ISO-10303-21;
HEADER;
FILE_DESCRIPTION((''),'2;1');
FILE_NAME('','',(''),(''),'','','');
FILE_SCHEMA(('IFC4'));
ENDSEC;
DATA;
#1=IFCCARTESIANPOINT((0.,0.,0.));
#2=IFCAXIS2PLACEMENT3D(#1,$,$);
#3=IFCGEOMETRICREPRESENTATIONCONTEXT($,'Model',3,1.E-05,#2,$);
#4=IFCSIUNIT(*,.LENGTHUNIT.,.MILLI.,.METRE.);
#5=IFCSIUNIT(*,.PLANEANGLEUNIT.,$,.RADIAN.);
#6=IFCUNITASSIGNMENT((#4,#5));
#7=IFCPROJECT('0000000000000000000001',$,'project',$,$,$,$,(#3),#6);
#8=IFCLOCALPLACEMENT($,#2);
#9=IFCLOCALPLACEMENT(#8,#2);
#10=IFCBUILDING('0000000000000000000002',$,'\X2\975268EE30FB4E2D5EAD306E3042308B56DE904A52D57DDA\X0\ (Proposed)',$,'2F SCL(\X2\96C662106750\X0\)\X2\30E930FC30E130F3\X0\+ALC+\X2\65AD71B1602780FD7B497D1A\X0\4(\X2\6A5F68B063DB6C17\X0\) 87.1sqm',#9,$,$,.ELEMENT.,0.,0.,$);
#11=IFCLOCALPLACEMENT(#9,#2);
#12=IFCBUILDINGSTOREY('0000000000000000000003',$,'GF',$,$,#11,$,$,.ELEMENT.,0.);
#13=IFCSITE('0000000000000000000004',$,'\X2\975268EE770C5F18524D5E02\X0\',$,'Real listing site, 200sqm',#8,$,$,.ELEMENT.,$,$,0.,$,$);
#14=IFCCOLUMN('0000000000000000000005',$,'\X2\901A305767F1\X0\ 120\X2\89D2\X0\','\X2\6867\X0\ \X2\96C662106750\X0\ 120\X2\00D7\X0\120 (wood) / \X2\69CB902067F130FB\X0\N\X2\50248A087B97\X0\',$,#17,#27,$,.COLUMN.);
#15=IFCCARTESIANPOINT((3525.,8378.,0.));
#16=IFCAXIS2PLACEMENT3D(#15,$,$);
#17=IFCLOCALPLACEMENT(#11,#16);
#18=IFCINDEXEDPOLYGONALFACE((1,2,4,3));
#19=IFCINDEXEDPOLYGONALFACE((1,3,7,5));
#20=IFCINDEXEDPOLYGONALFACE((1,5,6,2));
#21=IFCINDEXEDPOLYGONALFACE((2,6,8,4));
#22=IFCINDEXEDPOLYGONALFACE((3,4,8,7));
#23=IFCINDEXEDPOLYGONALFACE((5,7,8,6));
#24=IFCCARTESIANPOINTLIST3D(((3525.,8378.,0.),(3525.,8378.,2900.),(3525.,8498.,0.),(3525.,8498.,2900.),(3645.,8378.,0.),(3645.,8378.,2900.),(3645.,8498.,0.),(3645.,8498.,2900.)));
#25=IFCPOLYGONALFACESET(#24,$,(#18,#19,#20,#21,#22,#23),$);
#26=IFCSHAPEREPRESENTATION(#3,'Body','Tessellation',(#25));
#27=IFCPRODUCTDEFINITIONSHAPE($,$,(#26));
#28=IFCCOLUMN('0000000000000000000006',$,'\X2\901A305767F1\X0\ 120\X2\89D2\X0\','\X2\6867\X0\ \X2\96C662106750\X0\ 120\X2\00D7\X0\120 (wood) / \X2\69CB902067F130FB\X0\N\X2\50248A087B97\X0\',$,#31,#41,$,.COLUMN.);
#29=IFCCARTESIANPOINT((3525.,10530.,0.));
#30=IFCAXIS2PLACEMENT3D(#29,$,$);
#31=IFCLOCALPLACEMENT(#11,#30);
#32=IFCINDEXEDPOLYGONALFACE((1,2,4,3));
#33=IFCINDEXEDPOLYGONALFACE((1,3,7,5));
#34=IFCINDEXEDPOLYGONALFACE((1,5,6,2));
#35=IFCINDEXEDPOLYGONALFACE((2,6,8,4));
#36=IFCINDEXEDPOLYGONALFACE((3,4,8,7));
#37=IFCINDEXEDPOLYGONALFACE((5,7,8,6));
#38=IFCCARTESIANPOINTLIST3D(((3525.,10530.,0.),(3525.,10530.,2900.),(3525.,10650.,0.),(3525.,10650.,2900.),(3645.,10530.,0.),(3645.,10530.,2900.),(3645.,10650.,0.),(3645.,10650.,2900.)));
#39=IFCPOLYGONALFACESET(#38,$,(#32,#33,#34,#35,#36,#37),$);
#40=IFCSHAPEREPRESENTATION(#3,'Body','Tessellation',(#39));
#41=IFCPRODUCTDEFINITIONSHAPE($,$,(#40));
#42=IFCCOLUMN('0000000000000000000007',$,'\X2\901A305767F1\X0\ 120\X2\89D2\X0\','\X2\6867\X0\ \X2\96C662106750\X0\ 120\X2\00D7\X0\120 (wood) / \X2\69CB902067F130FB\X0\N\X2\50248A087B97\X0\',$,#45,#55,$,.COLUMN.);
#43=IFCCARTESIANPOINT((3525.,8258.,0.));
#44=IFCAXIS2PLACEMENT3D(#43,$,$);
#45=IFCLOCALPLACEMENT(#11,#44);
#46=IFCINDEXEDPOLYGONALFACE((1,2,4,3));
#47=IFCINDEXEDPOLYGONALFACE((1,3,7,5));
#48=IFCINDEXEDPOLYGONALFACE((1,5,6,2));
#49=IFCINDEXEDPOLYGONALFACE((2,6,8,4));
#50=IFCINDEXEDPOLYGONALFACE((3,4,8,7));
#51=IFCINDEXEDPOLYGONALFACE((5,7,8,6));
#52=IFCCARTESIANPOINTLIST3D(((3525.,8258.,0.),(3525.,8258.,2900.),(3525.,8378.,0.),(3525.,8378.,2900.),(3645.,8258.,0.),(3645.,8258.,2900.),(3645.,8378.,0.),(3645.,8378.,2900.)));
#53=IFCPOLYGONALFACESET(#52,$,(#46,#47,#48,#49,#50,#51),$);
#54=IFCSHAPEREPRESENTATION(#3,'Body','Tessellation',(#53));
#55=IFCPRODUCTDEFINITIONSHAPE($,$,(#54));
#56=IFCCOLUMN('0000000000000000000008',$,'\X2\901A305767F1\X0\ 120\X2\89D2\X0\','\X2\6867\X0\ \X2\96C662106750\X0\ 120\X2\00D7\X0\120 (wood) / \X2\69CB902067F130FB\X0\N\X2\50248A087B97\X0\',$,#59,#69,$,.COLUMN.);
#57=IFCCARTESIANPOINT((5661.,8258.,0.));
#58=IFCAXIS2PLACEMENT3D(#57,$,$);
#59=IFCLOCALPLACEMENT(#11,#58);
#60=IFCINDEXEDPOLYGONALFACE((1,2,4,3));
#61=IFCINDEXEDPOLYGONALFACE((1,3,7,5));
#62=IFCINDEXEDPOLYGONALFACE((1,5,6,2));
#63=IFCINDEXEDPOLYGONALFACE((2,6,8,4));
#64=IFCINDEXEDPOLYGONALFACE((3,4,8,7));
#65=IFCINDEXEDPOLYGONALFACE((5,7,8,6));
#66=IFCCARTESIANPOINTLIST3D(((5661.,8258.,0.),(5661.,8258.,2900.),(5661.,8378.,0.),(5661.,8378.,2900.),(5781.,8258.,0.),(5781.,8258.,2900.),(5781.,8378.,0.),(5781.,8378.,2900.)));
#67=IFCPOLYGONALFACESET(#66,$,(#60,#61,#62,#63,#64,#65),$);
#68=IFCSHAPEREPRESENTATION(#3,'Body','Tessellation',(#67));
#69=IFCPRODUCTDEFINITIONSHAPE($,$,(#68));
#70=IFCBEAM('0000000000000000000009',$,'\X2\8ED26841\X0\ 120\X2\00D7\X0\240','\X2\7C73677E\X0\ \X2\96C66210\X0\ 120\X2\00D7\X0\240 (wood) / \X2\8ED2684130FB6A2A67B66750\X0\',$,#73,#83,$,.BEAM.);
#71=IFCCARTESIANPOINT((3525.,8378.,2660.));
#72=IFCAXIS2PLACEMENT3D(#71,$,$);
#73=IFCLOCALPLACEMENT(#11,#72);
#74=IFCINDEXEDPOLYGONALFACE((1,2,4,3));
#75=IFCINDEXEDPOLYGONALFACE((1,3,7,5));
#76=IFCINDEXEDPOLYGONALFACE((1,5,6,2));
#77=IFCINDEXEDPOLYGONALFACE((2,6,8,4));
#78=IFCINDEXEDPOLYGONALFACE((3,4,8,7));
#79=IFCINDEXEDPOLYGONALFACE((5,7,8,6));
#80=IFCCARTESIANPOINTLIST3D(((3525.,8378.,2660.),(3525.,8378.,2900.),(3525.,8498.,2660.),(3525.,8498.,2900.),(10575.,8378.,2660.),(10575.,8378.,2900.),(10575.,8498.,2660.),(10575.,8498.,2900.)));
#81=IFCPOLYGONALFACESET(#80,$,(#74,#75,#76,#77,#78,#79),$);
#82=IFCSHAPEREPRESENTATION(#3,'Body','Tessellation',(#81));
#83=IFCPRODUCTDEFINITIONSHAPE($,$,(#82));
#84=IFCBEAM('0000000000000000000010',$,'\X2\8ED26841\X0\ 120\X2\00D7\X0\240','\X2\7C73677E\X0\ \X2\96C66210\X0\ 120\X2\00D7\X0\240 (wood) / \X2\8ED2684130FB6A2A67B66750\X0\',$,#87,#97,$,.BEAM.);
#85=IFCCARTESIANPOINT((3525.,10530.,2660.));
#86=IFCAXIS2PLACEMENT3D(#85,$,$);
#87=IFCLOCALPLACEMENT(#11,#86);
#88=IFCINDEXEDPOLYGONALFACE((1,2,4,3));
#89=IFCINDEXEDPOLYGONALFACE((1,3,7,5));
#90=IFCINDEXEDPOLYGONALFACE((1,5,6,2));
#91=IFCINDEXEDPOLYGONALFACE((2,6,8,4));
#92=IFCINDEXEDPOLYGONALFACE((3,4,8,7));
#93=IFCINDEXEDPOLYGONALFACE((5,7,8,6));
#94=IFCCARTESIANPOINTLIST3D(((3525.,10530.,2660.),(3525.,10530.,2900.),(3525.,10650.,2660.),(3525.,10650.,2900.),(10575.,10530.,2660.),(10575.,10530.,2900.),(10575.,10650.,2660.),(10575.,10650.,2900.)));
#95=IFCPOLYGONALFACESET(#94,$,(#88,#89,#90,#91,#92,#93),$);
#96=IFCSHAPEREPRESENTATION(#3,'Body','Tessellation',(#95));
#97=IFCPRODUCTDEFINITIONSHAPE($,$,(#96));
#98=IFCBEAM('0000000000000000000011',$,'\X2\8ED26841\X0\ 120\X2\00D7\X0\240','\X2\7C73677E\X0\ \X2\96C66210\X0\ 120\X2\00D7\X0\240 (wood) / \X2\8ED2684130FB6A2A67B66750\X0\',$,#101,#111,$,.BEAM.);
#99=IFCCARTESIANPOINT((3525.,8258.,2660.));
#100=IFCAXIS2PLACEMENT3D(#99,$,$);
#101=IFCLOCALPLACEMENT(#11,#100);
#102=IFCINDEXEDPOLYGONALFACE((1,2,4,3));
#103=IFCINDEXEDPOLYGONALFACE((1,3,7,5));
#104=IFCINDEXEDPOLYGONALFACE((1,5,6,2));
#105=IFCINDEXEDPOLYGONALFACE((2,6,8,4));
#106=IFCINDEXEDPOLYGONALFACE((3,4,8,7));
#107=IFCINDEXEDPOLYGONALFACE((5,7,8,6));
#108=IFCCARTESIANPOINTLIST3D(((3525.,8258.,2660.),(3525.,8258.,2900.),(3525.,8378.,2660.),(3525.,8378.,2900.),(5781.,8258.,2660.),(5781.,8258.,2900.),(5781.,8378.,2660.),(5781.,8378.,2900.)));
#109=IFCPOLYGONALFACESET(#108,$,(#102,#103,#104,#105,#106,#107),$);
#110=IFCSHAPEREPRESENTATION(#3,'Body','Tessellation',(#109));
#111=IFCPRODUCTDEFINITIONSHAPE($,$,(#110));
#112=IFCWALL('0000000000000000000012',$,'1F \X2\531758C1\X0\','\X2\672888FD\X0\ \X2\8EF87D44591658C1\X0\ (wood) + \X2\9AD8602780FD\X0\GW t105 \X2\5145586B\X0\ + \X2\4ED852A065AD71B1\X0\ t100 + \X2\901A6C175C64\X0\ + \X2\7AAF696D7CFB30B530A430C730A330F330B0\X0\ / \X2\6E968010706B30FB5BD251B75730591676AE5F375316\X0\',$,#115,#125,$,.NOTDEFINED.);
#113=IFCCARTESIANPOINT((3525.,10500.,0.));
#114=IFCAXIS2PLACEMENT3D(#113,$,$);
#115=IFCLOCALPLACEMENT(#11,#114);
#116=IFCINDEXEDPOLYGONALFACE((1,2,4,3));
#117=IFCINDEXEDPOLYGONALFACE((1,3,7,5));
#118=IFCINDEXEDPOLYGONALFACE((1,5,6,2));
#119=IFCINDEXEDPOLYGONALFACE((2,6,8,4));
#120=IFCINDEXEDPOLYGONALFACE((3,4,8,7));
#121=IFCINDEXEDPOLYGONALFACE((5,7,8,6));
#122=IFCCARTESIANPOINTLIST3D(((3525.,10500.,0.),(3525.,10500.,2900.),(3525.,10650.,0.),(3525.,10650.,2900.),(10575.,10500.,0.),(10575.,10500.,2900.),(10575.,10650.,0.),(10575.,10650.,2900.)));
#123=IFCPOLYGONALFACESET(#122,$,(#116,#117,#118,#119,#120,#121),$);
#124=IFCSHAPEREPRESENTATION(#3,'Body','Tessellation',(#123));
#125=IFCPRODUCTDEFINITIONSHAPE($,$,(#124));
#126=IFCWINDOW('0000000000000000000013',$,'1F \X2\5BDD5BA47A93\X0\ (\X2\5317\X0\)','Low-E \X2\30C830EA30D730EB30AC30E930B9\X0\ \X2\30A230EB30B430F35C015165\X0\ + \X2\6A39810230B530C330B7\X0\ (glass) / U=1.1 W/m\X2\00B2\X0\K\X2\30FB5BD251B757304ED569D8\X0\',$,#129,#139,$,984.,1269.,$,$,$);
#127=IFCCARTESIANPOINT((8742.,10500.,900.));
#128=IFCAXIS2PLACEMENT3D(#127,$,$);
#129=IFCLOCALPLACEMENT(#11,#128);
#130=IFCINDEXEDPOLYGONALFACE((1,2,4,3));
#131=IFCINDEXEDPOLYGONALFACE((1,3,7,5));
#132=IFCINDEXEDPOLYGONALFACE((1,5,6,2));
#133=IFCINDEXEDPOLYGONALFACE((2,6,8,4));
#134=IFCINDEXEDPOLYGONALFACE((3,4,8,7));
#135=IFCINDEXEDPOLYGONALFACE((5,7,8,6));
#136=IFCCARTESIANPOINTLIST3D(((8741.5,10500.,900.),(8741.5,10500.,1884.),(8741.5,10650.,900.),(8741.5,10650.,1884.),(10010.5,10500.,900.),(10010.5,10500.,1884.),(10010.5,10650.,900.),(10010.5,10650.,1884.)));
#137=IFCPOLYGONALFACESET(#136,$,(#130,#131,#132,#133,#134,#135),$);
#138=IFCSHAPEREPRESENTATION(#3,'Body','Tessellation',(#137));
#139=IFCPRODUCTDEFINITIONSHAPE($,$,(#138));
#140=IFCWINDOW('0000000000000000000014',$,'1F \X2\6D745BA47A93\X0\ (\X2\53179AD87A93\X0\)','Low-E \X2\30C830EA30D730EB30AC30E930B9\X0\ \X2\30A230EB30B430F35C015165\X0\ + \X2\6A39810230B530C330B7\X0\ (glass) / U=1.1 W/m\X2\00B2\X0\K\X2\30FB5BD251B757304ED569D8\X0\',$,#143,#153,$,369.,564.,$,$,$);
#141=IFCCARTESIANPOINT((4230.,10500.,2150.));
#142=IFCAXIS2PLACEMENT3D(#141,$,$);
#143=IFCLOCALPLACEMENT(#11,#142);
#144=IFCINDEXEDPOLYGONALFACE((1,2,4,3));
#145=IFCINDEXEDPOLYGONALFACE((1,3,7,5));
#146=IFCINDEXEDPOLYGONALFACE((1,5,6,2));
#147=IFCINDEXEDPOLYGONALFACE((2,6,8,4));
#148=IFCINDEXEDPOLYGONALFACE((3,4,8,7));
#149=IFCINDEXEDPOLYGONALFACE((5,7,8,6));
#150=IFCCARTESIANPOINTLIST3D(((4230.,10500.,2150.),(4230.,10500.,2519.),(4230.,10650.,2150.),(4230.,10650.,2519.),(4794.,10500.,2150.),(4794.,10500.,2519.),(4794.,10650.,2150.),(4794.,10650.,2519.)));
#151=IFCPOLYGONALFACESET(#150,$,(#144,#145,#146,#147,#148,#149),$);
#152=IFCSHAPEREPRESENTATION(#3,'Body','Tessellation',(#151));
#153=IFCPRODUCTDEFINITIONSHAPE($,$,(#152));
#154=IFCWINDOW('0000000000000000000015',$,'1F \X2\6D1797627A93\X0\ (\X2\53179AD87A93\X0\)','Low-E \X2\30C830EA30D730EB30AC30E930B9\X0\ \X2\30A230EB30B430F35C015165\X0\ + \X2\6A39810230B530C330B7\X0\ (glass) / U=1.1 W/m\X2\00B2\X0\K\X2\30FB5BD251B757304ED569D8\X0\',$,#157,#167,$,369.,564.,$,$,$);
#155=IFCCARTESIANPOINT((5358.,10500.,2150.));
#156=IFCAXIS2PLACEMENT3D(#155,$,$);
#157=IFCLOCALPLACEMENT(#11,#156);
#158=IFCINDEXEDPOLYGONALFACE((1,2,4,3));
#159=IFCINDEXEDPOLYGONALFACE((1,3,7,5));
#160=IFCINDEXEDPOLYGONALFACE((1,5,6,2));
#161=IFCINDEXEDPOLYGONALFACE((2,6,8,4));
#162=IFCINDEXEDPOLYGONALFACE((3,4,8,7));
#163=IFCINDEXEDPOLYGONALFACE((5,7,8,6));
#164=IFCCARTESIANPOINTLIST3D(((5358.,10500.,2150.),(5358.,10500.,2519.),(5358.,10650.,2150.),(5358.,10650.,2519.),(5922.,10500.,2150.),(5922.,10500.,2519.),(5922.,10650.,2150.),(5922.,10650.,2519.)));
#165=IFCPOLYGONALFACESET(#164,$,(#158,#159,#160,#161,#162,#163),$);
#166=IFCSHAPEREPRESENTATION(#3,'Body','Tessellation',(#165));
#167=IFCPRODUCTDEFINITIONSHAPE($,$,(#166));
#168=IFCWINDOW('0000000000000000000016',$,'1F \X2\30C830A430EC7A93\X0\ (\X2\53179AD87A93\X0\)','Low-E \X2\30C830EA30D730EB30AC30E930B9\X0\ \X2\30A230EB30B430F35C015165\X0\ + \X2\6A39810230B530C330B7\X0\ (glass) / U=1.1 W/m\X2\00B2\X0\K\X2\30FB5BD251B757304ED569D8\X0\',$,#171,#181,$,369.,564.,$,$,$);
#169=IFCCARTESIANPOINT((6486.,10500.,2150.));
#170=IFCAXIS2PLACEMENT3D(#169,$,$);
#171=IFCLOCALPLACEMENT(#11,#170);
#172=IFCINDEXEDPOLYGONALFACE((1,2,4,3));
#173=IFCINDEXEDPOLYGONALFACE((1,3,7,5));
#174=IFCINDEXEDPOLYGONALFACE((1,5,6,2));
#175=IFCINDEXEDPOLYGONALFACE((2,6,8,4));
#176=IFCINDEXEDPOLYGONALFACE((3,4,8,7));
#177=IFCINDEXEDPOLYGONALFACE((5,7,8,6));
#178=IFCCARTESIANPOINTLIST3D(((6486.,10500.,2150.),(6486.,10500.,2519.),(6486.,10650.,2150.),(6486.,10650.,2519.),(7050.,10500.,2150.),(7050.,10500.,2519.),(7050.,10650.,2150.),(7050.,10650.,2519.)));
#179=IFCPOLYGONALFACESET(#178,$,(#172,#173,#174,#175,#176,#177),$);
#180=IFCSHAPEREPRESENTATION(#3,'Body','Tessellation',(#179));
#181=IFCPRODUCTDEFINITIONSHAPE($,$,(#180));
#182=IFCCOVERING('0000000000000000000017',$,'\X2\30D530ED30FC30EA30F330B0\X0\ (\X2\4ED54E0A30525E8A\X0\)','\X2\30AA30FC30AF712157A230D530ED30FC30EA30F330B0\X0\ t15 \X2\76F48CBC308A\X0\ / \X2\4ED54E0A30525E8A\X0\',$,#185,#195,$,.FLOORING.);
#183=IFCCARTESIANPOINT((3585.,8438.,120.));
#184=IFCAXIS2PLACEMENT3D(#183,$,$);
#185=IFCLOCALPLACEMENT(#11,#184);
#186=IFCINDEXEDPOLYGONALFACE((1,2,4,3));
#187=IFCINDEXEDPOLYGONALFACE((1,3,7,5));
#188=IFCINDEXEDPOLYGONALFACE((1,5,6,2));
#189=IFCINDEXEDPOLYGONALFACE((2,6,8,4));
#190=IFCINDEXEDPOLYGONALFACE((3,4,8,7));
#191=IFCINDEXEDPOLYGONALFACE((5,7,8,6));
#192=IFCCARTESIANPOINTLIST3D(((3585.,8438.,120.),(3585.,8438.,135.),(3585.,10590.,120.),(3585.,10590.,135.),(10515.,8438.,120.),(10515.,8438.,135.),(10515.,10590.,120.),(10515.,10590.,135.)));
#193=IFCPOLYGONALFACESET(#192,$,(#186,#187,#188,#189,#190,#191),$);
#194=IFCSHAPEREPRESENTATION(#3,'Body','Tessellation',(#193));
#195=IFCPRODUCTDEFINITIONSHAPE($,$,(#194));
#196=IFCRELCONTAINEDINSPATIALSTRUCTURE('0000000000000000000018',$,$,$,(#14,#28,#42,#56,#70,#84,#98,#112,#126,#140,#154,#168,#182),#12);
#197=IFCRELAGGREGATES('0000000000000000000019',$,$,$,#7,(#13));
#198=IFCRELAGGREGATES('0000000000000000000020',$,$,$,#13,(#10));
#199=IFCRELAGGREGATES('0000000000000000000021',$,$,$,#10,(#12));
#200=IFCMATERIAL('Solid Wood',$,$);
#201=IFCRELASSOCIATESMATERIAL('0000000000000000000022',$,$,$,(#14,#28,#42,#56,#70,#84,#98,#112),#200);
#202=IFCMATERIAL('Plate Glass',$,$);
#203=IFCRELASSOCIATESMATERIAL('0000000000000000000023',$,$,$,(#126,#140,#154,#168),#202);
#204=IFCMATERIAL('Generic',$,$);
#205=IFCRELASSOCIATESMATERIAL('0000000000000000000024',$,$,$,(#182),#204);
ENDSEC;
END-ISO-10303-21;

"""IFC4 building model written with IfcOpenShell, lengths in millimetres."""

from ifc_helpers import new_model, si_unit, frame, frame_2d, origin, place, context, project, spatial, rectangle, extrude, material, element, fill, save


model = new_model("IFC4")

# Units and contexts
model_context = context("Model", 3, precision=1e-05, world=origin())
ifc_project = project(units=[si_unit("LENGTHUNIT", "METRE", prefix="MILLI"), si_unit("PLANEANGLEUNIT", "RADIAN")], contexts=[model_context])

# Site, building, storey
site_placement = place(None, origin())
site = spatial("IfcSite", under=ifc_project, at=site_placement, Name="青森県弘前市", ObjectType="Real listing site, 200sqm", CompositionType="ELEMENT", RefElevation=0.0)
building_placement = place(site_placement, origin())
building = spatial("IfcBuilding", under=site, at=building_placement, Name="青森・中庭のある回遊動線 (Proposed)", ObjectType="2F SCL(集成材)ラーメン+ALC+断熱性能等級4(機械換気) 87.1sqm", CompositionType="ELEMENT", ElevationOfRefHeight=0.0, ElevationOfTerrain=0.0)
storey_placement = place(building_placement, origin())
storey = spatial("IfcBuildingStorey", under=building, at=storey_placement, Name="GF", CompositionType="ELEMENT", Elevation=0.0)

# Columns
ifc_material_1 = material(Name="Solid Wood")
column_1_placement = place(storey_placement, frame((3525.0, 8378.0, 0.0)))
element("IfcColumn", 1, at=column_1_placement, inside=storey, material=ifc_material_1, Name="通し柱 120角", Description="桧 集成材 120×120 (wood) / 構造柱・N値計算", PredefinedType="COLUMN", context=model_context, shape_type="SweptSolid", body=[
    extrude(rectangle(XDim=120.0, YDim=120.0, at=frame_2d((60.0, 60.0))), frame((3525.0, 8378.0, 0.0)), (0.0, 0.0, 1.0), 2900.0),
])
column_2_placement = place(storey_placement, frame((3525.0, 10530.0, 0.0)))
element("IfcColumn", 2, at=column_2_placement, inside=storey, material=ifc_material_1, Name="通し柱 120角", Description="桧 集成材 120×120 (wood) / 構造柱・N値計算", PredefinedType="COLUMN", context=model_context, shape_type="SweptSolid", body=[
    extrude(rectangle(XDim=120.0, YDim=120.0, at=frame_2d((60.0, 60.0))), frame((3525.0, 10530.0, 0.0)), (0.0, 0.0, 1.0), 2900.0),
])
column_3_placement = place(storey_placement, frame((3525.0, 8258.0, 0.0)))
element("IfcColumn", 3, at=column_3_placement, inside=storey, material=ifc_material_1, Name="通し柱 120角", Description="桧 集成材 120×120 (wood) / 構造柱・N値計算", PredefinedType="COLUMN", context=model_context, shape_type="SweptSolid", body=[
    extrude(rectangle(XDim=120.0, YDim=120.0, at=frame_2d((60.0, 60.0))), frame((3525.0, 8258.0, 0.0)), (0.0, 0.0, 1.0), 2900.0),
])
column_4_placement = place(storey_placement, frame((5661.0, 8258.0, 0.0)))
element("IfcColumn", 4, at=column_4_placement, inside=storey, material=ifc_material_1, Name="通し柱 120角", Description="桧 集成材 120×120 (wood) / 構造柱・N値計算", PredefinedType="COLUMN", context=model_context, shape_type="SweptSolid", body=[
    extrude(rectangle(XDim=120.0, YDim=120.0, at=frame_2d((60.0, 60.0))), frame((5661.0, 8258.0, 0.0)), (0.0, 0.0, 1.0), 2900.0),
])

# Beams
beam_1_placement = place(storey_placement, frame((3525.0, 8378.0, 2660.0)))
element("IfcBeam", 5, at=beam_1_placement, inside=storey, material=ifc_material_1, Name="軒桁 120×240", Description="米松 集成 120×240 (wood) / 軒桁・横架材", PredefinedType="BEAM", context=model_context, shape_type="SweptSolid", body=[
    extrude(rectangle(XDim=7050.0, YDim=120.0, at=frame_2d((3525.0, 60.0))), frame((3525.0, 8378.0, 2660.0)), (0.0, 0.0, 1.0), 240.0),
])
beam_2_placement = place(storey_placement, frame((3525.0, 10530.0, 2660.0)))
element("IfcBeam", 6, at=beam_2_placement, inside=storey, material=ifc_material_1, Name="軒桁 120×240", Description="米松 集成 120×240 (wood) / 軒桁・横架材", PredefinedType="BEAM", context=model_context, shape_type="SweptSolid", body=[
    extrude(rectangle(XDim=7050.0, YDim=120.0, at=frame_2d((3525.0, 60.0))), frame((3525.0, 10530.0, 2660.0)), (0.0, 0.0, 1.0), 240.0),
])
beam_3_placement = place(storey_placement, frame((3525.0, 8258.0, 2660.0)))
element("IfcBeam", 7, at=beam_3_placement, inside=storey, material=ifc_material_1, Name="軒桁 120×240", Description="米松 集成 120×240 (wood) / 軒桁・横架材", PredefinedType="BEAM", context=model_context, shape_type="SweptSolid", body=[
    extrude(rectangle(XDim=2256.0, YDim=120.0, at=frame_2d((1128.0, 60.0))), frame((3525.0, 8258.0, 2660.0)), (0.0, 0.0, 1.0), 240.0),
])

# Wall, openings, windows
wall_1_placement = place(storey_placement, frame((3525.0, 10500.0, 0.0)))
wall_1 = element("IfcWall", 8, at=wall_1_placement, inside=storey, material=ifc_material_1, Name="1F 北壁", Description="木製 軸組外壁 (wood) + 高性能GW t105 充填 + 付加断熱 t100 + 通気層 + 窯業系サイディング / 準耐火・寒冷地外皮強化", PredefinedType="NOTDEFINED", context=model_context, shape_type="SweptSolid", body=[
    extrude(rectangle(XDim=7050.0, YDim=150.0, at=frame_2d((3525.0, 75.0))), frame((3525.0, 10500.0, 0.0)), (0.0, 0.0, 1.0), 2900.0),
])
opening_1_placement = place(storey_placement, frame((8742.0, 10500.0, 900.0)))
opening_1 = element("IfcOpeningElement", 9, at=opening_1_placement, cuts=wall_1, PredefinedType="NOTDEFINED", context=model_context, shape_type="SweptSolid", body=[
    extrude(rectangle(XDim=1269.0, YDim=150.0, at=frame_2d((634.0, 75.0))), frame((8742.0, 10500.0, 900.0)), (0.0, 0.0, 1.0), 984.0),
])
opening_2_placement = place(storey_placement, frame((4230.0, 10500.0, 2150.0)))
opening_2 = element("IfcOpeningElement", 10, at=opening_2_placement, cuts=wall_1, PredefinedType="NOTDEFINED", context=model_context, shape_type="SweptSolid", body=[
    extrude(rectangle(XDim=564.0, YDim=150.0, at=frame_2d((282.0, 75.0))), frame((4230.0, 10500.0, 2150.0)), (0.0, 0.0, 1.0), 369.0),
])
opening_3_placement = place(storey_placement, frame((5358.0, 10500.0, 2150.0)))
opening_3 = element("IfcOpeningElement", 11, at=opening_3_placement, cuts=wall_1, PredefinedType="NOTDEFINED", context=model_context, shape_type="SweptSolid", body=[
    extrude(rectangle(XDim=564.0, YDim=150.0, at=frame_2d((282.0, 75.0))), frame((5358.0, 10500.0, 2150.0)), (0.0, 0.0, 1.0), 369.0),
])
opening_4_placement = place(storey_placement, frame((6486.0, 10500.0, 2150.0)))
opening_4 = element("IfcOpeningElement", 12, at=opening_4_placement, cuts=wall_1, PredefinedType="NOTDEFINED", context=model_context, shape_type="SweptSolid", body=[
    extrude(rectangle(XDim=564.0, YDim=150.0, at=frame_2d((282.0, 75.0))), frame((6486.0, 10500.0, 2150.0)), (0.0, 0.0, 1.0), 369.0),
])
ifc_material_2 = material(Name="Plate Glass")
window_1_placement = place(storey_placement, frame((8742.0, 10500.0, 900.0)))
window_1 = element("IfcWindow", 13, at=window_1_placement, inside=storey, material=ifc_material_2, Name="1F 寝室窓 (北)", Description="Low-E トリプルガラス アルゴン封入 + 樹脂サッシ (glass) / U=1.1 W/m²K・寒冷地仕様", OverallHeight=984.0, OverallWidth=1269.0, context=model_context, shape_type="SweptSolid", body=[
    extrude(rectangle(XDim=1269.0, YDim=150.0, at=frame_2d((634.0, 75.0))), frame((8742.0, 10500.0, 900.0)), (0.0, 0.0, 1.0), 984.0),
])
fill(opening_1, window_1)
window_2_placement = place(storey_placement, frame((4230.0, 10500.0, 2150.0)))
window_2 = element("IfcWindow", 14, at=window_2_placement, inside=storey, material=ifc_material_2, Name="1F 浴室窓 (北高窓)", Description="Low-E トリプルガラス アルゴン封入 + 樹脂サッシ (glass) / U=1.1 W/m²K・寒冷地仕様", OverallHeight=369.0, OverallWidth=564.0, context=model_context, shape_type="SweptSolid", body=[
    extrude(rectangle(XDim=564.0, YDim=150.0, at=frame_2d((282.0, 75.0))), frame((4230.0, 10500.0, 2150.0)), (0.0, 0.0, 1.0), 369.0),
])
fill(opening_2, window_2)
window_3_placement = place(storey_placement, frame((5358.0, 10500.0, 2150.0)))
window_3 = element("IfcWindow", 15, at=window_3_placement, inside=storey, material=ifc_material_2, Name="1F 洗面窓 (北高窓)", Description="Low-E トリプルガラス アルゴン封入 + 樹脂サッシ (glass) / U=1.1 W/m²K・寒冷地仕様", OverallHeight=369.0, OverallWidth=564.0, context=model_context, shape_type="SweptSolid", body=[
    extrude(rectangle(XDim=564.0, YDim=150.0, at=frame_2d((282.0, 75.0))), frame((5358.0, 10500.0, 2150.0)), (0.0, 0.0, 1.0), 369.0),
])
fill(opening_3, window_3)
window_4_placement = place(storey_placement, frame((6486.0, 10500.0, 2150.0)))
window_4 = element("IfcWindow", 16, at=window_4_placement, inside=storey, material=ifc_material_2, Name="1F トイレ窓 (北高窓)", Description="Low-E トリプルガラス アルゴン封入 + 樹脂サッシ (glass) / U=1.1 W/m²K・寒冷地仕様", OverallHeight=369.0, OverallWidth=564.0, context=model_context, shape_type="SweptSolid", body=[
    extrude(rectangle(XDim=564.0, YDim=150.0, at=frame_2d((282.0, 75.0))), frame((6486.0, 10500.0, 2150.0)), (0.0, 0.0, 1.0), 369.0),
])
fill(opening_4, window_4)

# Covering
ifc_material_3 = material(Name="Generic")
covering_1_placement = place(storey_placement, frame((3585.0, 8438.0, 120.0)))
element("IfcCovering", 17, at=covering_1_placement, inside=storey, material=ifc_material_3, Name="フローリング (仕上げ床)", Description="オーク無垢フローリング t15 直貼り / 仕上げ床", PredefinedType="FLOORING", context=model_context, shape_type="SweptSolid", body=[
    extrude(rectangle(XDim=6930.0, YDim=2152.0, at=frame_2d((3465.0, 1076.0))), frame((3585.0, 8438.0, 120.0)), (0.0, 0.0, 1.0), 15.0),
])

save(model, "model.ifc")
